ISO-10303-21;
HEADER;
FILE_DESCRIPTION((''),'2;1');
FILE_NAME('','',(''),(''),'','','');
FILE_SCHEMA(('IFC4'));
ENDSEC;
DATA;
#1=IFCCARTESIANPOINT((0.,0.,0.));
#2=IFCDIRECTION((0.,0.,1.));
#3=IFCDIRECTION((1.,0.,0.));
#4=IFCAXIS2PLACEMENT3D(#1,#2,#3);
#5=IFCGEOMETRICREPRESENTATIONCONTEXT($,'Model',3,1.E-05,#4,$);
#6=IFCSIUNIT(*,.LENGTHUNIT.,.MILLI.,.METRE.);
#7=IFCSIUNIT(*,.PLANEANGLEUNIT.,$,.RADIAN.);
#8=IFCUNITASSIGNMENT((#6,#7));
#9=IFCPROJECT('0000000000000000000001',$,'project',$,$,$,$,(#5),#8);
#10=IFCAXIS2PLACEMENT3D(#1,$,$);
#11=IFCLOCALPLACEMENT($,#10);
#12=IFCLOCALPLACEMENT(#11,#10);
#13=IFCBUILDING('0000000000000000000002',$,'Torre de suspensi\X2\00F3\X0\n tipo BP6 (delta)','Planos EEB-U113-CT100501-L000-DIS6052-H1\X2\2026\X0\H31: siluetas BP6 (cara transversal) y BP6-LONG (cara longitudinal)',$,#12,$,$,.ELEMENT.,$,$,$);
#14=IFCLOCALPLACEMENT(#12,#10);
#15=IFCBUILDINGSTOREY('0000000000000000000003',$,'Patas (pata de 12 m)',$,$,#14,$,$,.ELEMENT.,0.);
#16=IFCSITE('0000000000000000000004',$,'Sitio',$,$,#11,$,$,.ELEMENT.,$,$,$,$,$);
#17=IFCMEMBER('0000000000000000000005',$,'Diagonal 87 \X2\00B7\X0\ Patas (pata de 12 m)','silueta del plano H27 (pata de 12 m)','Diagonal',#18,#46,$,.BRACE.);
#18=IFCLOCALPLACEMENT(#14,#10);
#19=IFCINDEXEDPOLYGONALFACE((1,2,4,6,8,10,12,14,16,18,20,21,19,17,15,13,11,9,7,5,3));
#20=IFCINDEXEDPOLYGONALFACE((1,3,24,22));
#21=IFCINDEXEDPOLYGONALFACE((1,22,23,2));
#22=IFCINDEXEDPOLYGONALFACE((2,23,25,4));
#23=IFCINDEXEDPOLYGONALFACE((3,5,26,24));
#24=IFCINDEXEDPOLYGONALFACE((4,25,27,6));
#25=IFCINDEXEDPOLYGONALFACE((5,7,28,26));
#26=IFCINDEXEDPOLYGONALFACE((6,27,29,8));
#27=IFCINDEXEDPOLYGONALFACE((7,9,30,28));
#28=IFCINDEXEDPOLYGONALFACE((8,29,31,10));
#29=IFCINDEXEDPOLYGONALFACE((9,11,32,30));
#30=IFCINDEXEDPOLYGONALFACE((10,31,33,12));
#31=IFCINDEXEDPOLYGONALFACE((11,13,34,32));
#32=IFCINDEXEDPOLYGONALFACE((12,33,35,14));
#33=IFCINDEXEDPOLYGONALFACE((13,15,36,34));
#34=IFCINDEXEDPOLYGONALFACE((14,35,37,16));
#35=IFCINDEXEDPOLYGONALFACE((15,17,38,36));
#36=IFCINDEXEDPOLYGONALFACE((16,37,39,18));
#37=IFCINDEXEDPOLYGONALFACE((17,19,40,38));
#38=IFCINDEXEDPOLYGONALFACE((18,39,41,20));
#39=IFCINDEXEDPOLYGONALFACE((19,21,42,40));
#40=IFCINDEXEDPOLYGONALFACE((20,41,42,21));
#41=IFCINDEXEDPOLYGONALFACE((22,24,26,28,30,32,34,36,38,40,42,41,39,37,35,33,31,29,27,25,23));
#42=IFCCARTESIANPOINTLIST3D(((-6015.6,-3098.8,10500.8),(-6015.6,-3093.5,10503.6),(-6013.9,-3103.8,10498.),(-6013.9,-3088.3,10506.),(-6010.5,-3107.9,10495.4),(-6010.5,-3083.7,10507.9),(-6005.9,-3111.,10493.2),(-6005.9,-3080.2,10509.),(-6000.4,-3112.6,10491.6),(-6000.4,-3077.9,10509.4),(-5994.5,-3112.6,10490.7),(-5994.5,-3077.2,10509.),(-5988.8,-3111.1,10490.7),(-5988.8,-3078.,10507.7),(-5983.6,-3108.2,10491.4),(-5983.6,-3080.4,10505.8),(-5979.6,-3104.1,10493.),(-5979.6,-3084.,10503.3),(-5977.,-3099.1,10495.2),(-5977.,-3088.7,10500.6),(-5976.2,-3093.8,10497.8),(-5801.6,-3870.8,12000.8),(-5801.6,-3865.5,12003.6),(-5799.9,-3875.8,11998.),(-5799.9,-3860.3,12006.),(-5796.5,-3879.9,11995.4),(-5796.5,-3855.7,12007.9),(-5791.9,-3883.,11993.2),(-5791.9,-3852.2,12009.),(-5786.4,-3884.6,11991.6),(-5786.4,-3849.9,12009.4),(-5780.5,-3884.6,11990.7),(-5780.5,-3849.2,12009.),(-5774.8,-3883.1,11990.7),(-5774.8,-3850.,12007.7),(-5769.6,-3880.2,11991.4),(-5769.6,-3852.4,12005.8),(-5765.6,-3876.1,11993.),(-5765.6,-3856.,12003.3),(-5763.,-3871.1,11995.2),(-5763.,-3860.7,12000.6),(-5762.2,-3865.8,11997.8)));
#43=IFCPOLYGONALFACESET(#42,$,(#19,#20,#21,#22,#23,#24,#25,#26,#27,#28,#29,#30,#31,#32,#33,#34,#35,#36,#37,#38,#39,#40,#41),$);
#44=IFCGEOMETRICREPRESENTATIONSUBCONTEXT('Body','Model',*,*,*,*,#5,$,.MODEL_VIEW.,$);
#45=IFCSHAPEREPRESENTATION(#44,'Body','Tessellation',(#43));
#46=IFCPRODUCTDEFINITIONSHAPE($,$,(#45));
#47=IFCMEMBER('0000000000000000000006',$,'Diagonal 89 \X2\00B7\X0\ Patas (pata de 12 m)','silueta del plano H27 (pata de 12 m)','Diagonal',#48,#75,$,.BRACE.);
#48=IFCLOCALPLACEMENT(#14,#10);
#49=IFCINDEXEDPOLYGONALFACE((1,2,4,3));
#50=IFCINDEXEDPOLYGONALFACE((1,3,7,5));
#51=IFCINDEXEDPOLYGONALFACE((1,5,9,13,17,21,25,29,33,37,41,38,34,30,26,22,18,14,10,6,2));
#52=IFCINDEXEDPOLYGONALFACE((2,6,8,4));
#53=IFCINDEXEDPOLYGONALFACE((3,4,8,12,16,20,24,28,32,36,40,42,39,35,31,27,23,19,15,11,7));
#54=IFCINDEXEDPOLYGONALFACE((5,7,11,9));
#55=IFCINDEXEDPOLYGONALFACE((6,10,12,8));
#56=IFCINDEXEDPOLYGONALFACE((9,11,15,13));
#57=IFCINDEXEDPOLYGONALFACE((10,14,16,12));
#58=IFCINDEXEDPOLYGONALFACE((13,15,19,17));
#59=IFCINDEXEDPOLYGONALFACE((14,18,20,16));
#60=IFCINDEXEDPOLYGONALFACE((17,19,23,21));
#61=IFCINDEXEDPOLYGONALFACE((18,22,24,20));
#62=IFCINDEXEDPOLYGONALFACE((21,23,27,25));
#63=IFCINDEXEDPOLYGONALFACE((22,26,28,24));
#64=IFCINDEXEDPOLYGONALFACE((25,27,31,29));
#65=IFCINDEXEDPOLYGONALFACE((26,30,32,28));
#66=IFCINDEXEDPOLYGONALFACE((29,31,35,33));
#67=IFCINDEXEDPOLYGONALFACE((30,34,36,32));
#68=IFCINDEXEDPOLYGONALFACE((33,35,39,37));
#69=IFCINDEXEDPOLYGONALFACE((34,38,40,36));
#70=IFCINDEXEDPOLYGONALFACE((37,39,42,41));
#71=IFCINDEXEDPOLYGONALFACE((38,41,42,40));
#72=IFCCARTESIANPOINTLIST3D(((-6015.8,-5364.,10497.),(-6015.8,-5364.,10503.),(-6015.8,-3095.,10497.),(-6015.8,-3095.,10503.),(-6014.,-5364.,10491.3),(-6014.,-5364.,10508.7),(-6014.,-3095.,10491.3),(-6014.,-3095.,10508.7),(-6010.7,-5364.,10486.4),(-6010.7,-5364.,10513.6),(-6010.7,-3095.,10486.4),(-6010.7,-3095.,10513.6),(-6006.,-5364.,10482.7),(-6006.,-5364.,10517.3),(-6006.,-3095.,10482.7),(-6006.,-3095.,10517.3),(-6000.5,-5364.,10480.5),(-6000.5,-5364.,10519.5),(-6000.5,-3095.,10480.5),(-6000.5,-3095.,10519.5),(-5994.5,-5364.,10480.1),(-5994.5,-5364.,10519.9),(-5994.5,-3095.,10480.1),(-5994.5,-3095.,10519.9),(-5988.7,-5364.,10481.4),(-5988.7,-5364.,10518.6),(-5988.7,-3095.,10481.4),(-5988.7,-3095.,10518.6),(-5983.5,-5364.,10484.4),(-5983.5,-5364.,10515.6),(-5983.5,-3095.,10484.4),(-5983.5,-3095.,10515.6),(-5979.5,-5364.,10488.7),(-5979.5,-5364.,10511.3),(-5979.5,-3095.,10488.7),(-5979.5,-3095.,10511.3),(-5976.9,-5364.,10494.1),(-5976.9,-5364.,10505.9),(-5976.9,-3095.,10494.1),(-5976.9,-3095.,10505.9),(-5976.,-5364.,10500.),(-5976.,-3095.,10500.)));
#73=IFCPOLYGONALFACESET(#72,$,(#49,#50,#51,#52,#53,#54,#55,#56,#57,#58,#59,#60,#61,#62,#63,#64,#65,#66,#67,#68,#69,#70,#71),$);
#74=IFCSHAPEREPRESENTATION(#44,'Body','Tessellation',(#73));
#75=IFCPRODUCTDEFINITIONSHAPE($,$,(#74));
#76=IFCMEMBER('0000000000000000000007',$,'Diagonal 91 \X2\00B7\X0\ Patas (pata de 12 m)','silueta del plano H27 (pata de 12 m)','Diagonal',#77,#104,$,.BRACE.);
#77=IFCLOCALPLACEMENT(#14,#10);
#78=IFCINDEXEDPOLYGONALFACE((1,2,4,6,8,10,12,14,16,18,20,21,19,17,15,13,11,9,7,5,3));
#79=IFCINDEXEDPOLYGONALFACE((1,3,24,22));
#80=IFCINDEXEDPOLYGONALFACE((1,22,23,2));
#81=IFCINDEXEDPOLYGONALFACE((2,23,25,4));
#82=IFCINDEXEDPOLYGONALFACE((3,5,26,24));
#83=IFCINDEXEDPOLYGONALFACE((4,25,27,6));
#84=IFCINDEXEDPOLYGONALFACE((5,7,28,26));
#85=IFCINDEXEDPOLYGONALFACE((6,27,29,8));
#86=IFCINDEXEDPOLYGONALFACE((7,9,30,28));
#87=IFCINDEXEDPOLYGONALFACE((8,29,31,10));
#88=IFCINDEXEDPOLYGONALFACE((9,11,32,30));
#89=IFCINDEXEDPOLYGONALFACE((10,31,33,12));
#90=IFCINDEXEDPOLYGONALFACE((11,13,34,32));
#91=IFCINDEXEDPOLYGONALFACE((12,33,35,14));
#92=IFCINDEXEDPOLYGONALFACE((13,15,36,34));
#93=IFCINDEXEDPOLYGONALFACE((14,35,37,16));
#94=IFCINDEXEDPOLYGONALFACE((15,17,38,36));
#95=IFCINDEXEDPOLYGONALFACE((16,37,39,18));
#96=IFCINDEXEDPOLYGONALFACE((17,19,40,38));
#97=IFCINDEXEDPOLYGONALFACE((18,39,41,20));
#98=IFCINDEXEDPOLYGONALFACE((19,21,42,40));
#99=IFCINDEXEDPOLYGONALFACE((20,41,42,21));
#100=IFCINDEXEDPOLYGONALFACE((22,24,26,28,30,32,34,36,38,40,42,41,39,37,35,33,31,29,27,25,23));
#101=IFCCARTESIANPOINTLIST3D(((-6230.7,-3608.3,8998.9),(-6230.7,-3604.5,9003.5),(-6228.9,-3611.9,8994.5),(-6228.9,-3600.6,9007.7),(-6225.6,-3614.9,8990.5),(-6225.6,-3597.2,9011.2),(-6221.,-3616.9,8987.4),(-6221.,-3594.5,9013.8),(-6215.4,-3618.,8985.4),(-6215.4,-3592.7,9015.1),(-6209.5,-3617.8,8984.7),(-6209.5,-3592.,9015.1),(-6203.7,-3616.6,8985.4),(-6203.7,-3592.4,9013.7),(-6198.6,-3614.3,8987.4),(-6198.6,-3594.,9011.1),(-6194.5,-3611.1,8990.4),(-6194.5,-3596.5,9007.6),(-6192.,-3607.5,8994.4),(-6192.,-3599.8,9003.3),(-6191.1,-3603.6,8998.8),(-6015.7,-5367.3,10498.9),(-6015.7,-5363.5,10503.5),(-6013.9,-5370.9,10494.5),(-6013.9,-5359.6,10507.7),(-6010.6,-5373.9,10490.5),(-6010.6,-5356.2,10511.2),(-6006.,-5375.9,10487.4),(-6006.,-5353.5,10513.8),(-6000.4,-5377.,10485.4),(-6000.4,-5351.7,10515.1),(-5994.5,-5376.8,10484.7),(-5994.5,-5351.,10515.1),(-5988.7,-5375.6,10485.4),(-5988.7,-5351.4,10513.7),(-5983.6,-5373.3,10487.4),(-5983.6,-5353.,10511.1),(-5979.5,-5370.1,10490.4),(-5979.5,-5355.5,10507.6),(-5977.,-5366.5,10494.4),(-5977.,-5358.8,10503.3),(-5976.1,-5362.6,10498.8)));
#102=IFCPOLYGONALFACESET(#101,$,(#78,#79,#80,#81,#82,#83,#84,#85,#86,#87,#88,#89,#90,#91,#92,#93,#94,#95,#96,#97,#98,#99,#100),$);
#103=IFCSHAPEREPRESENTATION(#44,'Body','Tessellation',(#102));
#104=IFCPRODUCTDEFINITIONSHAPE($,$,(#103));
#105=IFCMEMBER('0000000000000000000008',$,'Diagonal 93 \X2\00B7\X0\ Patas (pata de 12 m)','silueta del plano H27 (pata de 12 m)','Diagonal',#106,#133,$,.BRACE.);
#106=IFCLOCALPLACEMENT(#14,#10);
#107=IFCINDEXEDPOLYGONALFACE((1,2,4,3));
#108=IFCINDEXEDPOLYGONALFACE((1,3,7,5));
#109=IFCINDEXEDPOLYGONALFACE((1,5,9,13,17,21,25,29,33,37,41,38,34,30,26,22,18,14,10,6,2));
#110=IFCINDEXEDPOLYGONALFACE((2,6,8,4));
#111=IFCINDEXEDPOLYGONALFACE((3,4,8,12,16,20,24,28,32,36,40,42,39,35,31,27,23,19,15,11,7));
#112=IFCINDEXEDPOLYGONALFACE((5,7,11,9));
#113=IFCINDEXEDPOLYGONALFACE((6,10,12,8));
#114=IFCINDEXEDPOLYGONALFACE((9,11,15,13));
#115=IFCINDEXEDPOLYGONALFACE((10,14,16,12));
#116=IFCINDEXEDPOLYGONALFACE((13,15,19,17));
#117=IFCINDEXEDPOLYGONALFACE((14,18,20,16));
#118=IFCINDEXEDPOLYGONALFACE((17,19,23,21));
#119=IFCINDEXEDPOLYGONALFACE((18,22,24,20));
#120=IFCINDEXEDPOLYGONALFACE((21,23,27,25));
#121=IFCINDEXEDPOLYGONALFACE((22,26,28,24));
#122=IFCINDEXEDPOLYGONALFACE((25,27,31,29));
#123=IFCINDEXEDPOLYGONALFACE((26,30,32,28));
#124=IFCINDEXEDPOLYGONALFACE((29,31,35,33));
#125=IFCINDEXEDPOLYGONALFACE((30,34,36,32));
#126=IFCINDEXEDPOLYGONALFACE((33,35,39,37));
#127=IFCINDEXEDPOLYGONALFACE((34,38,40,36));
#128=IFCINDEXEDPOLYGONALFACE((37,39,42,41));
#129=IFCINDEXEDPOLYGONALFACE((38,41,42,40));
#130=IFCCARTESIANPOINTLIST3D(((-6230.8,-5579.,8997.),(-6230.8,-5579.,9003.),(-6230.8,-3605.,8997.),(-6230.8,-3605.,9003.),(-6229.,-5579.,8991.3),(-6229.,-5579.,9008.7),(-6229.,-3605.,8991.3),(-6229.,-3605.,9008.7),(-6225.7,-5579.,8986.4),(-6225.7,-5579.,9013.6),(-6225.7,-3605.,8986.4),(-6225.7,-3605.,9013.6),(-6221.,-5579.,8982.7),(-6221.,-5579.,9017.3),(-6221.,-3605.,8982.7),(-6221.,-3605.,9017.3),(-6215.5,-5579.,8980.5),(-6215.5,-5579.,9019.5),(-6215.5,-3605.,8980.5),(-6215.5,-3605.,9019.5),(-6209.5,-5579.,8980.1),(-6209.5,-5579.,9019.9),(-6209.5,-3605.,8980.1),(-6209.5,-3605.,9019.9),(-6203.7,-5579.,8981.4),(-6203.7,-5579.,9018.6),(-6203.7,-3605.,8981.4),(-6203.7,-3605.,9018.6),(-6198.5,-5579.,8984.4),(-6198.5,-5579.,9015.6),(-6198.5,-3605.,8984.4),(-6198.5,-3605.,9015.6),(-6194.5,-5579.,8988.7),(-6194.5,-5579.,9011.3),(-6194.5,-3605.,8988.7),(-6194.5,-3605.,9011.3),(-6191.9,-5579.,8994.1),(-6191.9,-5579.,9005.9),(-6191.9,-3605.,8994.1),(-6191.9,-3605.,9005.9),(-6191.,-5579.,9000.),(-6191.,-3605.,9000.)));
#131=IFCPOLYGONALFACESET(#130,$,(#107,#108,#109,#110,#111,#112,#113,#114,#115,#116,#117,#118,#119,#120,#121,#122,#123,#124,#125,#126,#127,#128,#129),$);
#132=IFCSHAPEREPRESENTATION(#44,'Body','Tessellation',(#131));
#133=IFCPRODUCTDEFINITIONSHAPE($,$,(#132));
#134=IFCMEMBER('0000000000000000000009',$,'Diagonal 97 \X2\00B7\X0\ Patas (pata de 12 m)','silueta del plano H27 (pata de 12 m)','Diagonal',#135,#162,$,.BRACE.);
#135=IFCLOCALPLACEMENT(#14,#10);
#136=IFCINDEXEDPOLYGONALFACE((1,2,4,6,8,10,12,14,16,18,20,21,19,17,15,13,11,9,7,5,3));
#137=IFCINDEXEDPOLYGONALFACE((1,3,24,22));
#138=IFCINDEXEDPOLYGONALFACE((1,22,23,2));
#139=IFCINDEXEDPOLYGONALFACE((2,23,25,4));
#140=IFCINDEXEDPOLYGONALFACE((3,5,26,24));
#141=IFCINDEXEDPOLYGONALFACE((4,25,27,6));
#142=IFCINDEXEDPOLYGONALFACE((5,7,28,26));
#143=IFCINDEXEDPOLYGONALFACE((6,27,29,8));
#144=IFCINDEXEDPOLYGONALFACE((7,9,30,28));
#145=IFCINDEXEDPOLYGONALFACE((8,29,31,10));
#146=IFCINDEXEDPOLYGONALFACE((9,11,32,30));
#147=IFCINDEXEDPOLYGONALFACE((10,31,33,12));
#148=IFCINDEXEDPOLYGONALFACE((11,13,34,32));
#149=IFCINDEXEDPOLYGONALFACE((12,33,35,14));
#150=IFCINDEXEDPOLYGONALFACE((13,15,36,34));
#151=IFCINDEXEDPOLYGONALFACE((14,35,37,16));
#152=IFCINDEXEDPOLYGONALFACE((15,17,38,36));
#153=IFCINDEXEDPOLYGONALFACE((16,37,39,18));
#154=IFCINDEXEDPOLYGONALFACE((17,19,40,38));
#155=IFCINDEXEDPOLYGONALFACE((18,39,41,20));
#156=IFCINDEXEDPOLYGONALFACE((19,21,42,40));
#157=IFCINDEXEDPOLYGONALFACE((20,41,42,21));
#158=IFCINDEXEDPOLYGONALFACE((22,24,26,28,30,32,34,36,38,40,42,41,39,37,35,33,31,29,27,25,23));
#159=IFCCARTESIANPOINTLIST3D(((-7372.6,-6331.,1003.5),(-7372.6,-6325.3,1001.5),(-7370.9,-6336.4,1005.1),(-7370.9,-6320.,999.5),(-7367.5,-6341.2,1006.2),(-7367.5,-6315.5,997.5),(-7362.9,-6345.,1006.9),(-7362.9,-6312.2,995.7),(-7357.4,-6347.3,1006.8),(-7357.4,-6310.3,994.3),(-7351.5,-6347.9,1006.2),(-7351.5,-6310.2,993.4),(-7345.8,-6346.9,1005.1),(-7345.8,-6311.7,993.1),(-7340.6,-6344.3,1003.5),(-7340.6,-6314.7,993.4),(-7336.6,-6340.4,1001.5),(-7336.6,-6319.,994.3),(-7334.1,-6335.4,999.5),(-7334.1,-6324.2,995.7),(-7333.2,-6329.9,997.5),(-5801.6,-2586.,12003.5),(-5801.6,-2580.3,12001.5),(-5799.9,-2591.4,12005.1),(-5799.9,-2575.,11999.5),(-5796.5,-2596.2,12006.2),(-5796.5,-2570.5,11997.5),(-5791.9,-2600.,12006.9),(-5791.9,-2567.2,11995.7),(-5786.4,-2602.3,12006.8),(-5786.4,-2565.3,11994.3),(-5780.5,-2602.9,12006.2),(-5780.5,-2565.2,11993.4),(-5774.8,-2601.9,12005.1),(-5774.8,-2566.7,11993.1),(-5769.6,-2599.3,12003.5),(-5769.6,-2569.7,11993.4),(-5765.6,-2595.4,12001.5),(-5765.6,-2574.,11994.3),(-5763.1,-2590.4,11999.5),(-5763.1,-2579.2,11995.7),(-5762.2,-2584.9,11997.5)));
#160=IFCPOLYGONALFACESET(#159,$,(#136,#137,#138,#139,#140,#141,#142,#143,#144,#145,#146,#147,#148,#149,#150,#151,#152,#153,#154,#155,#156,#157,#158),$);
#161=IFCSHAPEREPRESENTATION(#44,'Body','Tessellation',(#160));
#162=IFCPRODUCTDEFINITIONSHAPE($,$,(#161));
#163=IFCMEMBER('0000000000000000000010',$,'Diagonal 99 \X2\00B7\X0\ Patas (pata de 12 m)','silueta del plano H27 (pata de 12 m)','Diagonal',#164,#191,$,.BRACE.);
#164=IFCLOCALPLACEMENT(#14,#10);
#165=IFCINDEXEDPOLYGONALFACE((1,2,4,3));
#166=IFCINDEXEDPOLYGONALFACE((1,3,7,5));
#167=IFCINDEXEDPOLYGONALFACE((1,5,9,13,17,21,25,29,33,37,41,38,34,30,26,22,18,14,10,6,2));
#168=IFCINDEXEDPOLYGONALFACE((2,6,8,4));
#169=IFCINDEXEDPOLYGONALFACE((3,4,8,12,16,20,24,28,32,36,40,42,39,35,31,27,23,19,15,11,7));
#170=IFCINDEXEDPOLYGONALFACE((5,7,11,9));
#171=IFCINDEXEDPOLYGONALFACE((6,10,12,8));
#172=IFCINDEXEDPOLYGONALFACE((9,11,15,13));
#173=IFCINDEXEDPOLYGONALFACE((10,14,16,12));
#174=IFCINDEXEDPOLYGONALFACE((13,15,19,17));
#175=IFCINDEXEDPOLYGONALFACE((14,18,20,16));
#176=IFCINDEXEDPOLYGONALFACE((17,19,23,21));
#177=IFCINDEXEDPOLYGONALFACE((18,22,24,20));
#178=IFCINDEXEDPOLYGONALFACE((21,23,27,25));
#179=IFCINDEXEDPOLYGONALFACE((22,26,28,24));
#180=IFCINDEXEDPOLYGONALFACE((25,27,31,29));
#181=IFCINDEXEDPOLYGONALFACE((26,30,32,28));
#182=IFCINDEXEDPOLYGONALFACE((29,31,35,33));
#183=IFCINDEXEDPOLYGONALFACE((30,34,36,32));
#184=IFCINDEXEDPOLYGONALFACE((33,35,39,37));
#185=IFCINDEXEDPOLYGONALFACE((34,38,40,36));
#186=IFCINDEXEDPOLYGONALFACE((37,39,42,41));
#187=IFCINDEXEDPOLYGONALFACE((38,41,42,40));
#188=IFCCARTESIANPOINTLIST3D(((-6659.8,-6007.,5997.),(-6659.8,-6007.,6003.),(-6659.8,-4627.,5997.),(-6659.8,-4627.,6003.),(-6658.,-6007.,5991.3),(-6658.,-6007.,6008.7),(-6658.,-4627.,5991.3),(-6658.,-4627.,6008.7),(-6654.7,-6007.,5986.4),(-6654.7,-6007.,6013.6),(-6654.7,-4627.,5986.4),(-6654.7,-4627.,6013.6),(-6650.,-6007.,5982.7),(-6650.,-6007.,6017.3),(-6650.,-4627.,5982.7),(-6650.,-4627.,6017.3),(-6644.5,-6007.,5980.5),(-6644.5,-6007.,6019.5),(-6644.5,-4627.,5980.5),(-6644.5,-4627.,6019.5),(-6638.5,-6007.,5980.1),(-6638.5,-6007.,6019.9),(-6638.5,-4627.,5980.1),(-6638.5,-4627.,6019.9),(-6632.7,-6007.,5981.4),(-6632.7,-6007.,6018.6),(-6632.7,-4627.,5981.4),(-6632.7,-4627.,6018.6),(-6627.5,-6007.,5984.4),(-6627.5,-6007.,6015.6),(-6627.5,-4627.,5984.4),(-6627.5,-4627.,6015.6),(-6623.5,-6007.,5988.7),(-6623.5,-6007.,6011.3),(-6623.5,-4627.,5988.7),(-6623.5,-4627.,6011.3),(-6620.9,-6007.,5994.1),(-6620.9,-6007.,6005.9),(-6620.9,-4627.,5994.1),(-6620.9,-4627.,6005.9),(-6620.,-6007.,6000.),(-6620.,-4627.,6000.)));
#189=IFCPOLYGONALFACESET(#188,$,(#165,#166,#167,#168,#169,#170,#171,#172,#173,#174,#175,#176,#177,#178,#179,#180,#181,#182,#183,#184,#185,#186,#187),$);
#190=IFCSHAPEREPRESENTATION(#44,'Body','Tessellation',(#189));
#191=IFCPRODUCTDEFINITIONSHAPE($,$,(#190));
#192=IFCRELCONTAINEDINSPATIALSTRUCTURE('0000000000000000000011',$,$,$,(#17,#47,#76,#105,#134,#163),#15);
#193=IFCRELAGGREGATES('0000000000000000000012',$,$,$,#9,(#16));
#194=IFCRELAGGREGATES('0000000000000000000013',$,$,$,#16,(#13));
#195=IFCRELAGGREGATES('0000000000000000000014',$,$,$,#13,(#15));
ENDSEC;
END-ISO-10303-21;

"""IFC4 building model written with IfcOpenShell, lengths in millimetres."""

from ifc_helpers import new_model, si_unit, frame, origin, origin_with_axes, place, context, subcontext, project, spatial, circle, extrude, element, save


model = new_model("IFC4")

# Units and contexts
model_context = context("Model", 3, precision=1e-05, world=origin_with_axes())
body_context = subcontext(model_context, "Body", "Model", "MODEL_VIEW")
ifc_project = project(units=[si_unit("LENGTHUNIT", "METRE", prefix="MILLI"), si_unit("PLANEANGLEUNIT", "RADIAN")], contexts=[model_context])

# Site, building, storey
site_placement = place(None, origin())
site = spatial("IfcSite", under=ifc_project, at=site_placement, Name="Sitio", CompositionType="ELEMENT")
building_placement = place(site_placement, origin())
building = spatial("IfcBuilding", under=site, at=building_placement, Name="Torre de suspensión tipo BP6 (delta)", Description="Planos EEB-U113-CT100501-L000-DIS6052-H1…H31: siluetas BP6 (cara transversal) y BP6-LONG (cara longitudinal)", CompositionType="ELEMENT")
storey_placement = place(building_placement, origin())
storey = spatial("IfcBuildingStorey", under=building, at=storey_placement, Name="Patas (pata de 12 m)", CompositionType="ELEMENT", Elevation=0.0)

# Members
member_1_placement = place(storey_placement, frame((-5782.0, -3867.0, 12000.0), z_axis=(-0.125844, 0.453978, -0.882081), x_axis=(0.99205, 0.057588, -0.111894)))
element("IfcMember", 1, at=member_1_placement, inside=storey, Name="Diagonal 87 · Patas (pata de 12 m)", Description="silueta del plano H27 (pata de 12 m)", ObjectType="Diagonal", PredefinedType="BRACE", context=body_context, shape_type="SweptSolid", body=[
    extrude(circle(Radius=20.0), None, (0.0, 0.0, 1.0), 1700.5),
])
member_2_placement = place(storey_placement, frame((-5996.0, -3095.0, 10500.0), z_axis=(0.0, -1.0, 0.0), x_axis=(1.0, 0.0, 0.0)))
element("IfcMember", 2, at=member_2_placement, inside=storey, Name="Diagonal 89 · Patas (pata de 12 m)", Description="silueta del plano H27 (pata de 12 m)", ObjectType="Diagonal", PredefinedType="BRACE", context=body_context, shape_type="SweptSolid", body=[
    extrude(circle(Radius=20.0), None, (0.0, 0.0, 1.0), 2269.0),
])
member_3_placement = place(storey_placement, frame((-6211.0, -3605.0, 9000.0), z_axis=(0.092604, -0.757633, 0.646077), x_axis=(0.995703, 0.070463, -0.060088)))
element("IfcMember", 3, at=member_3_placement, inside=storey, Name="Diagonal 91 · Patas (pata de 12 m)", Description="silueta del plano H27 (pata de 12 m)", ObjectType="Diagonal", PredefinedType="BRACE", context=body_context, shape_type="SweptSolid", body=[
    extrude(circle(Radius=20.0), None, (0.0, 0.0, 1.0), 2321.7),
])
member_4_placement = place(storey_placement, frame((-6211.0, -5579.0, 9000.0), z_axis=(0.0, 1.0, 0.0), x_axis=(1.0, 0.0, 0.0)))
element("IfcMember", 4, at=member_4_placement, inside=storey, Name="Diagonal 93 · Patas (pata de 12 m)", Description="silueta del plano H27 (pata de 12 m)", ObjectType="Diagonal", PredefinedType="BRACE", context=body_context, shape_type="SweptSolid", body=[
    extrude(circle(Radius=20.0), None, (0.0, 0.0, 1.0), 1974.0),
])
member_5_placement = place(storey_placement, frame((-5782.0, -2584.0, 12000.0), z_axis=(-0.133979, -0.319383, -0.938107), x_axis=(0.990984, -0.04318, -0.12683)))
element("IfcMember", 5, at=member_5_placement, inside=storey, Name="Diagonal 97 · Patas (pata de 12 m)", Description="silueta del plano H27 (pata de 12 m)", ObjectType="Diagonal", PredefinedType="BRACE", context=body_context, shape_type="SweptSolid", body=[
    extrude(circle(Radius=20.0), None, (0.0, 0.0, 1.0), 11725.7),
])
member_6_placement = place(storey_placement, frame((-6640.0, -6007.0, 6000.0), z_axis=(0.0, 1.0, 0.0), x_axis=(1.0, 0.0, 0.0)))
element("IfcMember", 6, at=member_6_placement, inside=storey, Name="Diagonal 99 · Patas (pata de 12 m)", Description="silueta del plano H27 (pata de 12 m)", ObjectType="Diagonal", PredefinedType="BRACE", context=body_context, shape_type="SweptSolid", body=[
    extrude(circle(Radius=20.0), None, (0.0, 0.0, 1.0), 1380.0),
])

save(model, "model.ifc")
